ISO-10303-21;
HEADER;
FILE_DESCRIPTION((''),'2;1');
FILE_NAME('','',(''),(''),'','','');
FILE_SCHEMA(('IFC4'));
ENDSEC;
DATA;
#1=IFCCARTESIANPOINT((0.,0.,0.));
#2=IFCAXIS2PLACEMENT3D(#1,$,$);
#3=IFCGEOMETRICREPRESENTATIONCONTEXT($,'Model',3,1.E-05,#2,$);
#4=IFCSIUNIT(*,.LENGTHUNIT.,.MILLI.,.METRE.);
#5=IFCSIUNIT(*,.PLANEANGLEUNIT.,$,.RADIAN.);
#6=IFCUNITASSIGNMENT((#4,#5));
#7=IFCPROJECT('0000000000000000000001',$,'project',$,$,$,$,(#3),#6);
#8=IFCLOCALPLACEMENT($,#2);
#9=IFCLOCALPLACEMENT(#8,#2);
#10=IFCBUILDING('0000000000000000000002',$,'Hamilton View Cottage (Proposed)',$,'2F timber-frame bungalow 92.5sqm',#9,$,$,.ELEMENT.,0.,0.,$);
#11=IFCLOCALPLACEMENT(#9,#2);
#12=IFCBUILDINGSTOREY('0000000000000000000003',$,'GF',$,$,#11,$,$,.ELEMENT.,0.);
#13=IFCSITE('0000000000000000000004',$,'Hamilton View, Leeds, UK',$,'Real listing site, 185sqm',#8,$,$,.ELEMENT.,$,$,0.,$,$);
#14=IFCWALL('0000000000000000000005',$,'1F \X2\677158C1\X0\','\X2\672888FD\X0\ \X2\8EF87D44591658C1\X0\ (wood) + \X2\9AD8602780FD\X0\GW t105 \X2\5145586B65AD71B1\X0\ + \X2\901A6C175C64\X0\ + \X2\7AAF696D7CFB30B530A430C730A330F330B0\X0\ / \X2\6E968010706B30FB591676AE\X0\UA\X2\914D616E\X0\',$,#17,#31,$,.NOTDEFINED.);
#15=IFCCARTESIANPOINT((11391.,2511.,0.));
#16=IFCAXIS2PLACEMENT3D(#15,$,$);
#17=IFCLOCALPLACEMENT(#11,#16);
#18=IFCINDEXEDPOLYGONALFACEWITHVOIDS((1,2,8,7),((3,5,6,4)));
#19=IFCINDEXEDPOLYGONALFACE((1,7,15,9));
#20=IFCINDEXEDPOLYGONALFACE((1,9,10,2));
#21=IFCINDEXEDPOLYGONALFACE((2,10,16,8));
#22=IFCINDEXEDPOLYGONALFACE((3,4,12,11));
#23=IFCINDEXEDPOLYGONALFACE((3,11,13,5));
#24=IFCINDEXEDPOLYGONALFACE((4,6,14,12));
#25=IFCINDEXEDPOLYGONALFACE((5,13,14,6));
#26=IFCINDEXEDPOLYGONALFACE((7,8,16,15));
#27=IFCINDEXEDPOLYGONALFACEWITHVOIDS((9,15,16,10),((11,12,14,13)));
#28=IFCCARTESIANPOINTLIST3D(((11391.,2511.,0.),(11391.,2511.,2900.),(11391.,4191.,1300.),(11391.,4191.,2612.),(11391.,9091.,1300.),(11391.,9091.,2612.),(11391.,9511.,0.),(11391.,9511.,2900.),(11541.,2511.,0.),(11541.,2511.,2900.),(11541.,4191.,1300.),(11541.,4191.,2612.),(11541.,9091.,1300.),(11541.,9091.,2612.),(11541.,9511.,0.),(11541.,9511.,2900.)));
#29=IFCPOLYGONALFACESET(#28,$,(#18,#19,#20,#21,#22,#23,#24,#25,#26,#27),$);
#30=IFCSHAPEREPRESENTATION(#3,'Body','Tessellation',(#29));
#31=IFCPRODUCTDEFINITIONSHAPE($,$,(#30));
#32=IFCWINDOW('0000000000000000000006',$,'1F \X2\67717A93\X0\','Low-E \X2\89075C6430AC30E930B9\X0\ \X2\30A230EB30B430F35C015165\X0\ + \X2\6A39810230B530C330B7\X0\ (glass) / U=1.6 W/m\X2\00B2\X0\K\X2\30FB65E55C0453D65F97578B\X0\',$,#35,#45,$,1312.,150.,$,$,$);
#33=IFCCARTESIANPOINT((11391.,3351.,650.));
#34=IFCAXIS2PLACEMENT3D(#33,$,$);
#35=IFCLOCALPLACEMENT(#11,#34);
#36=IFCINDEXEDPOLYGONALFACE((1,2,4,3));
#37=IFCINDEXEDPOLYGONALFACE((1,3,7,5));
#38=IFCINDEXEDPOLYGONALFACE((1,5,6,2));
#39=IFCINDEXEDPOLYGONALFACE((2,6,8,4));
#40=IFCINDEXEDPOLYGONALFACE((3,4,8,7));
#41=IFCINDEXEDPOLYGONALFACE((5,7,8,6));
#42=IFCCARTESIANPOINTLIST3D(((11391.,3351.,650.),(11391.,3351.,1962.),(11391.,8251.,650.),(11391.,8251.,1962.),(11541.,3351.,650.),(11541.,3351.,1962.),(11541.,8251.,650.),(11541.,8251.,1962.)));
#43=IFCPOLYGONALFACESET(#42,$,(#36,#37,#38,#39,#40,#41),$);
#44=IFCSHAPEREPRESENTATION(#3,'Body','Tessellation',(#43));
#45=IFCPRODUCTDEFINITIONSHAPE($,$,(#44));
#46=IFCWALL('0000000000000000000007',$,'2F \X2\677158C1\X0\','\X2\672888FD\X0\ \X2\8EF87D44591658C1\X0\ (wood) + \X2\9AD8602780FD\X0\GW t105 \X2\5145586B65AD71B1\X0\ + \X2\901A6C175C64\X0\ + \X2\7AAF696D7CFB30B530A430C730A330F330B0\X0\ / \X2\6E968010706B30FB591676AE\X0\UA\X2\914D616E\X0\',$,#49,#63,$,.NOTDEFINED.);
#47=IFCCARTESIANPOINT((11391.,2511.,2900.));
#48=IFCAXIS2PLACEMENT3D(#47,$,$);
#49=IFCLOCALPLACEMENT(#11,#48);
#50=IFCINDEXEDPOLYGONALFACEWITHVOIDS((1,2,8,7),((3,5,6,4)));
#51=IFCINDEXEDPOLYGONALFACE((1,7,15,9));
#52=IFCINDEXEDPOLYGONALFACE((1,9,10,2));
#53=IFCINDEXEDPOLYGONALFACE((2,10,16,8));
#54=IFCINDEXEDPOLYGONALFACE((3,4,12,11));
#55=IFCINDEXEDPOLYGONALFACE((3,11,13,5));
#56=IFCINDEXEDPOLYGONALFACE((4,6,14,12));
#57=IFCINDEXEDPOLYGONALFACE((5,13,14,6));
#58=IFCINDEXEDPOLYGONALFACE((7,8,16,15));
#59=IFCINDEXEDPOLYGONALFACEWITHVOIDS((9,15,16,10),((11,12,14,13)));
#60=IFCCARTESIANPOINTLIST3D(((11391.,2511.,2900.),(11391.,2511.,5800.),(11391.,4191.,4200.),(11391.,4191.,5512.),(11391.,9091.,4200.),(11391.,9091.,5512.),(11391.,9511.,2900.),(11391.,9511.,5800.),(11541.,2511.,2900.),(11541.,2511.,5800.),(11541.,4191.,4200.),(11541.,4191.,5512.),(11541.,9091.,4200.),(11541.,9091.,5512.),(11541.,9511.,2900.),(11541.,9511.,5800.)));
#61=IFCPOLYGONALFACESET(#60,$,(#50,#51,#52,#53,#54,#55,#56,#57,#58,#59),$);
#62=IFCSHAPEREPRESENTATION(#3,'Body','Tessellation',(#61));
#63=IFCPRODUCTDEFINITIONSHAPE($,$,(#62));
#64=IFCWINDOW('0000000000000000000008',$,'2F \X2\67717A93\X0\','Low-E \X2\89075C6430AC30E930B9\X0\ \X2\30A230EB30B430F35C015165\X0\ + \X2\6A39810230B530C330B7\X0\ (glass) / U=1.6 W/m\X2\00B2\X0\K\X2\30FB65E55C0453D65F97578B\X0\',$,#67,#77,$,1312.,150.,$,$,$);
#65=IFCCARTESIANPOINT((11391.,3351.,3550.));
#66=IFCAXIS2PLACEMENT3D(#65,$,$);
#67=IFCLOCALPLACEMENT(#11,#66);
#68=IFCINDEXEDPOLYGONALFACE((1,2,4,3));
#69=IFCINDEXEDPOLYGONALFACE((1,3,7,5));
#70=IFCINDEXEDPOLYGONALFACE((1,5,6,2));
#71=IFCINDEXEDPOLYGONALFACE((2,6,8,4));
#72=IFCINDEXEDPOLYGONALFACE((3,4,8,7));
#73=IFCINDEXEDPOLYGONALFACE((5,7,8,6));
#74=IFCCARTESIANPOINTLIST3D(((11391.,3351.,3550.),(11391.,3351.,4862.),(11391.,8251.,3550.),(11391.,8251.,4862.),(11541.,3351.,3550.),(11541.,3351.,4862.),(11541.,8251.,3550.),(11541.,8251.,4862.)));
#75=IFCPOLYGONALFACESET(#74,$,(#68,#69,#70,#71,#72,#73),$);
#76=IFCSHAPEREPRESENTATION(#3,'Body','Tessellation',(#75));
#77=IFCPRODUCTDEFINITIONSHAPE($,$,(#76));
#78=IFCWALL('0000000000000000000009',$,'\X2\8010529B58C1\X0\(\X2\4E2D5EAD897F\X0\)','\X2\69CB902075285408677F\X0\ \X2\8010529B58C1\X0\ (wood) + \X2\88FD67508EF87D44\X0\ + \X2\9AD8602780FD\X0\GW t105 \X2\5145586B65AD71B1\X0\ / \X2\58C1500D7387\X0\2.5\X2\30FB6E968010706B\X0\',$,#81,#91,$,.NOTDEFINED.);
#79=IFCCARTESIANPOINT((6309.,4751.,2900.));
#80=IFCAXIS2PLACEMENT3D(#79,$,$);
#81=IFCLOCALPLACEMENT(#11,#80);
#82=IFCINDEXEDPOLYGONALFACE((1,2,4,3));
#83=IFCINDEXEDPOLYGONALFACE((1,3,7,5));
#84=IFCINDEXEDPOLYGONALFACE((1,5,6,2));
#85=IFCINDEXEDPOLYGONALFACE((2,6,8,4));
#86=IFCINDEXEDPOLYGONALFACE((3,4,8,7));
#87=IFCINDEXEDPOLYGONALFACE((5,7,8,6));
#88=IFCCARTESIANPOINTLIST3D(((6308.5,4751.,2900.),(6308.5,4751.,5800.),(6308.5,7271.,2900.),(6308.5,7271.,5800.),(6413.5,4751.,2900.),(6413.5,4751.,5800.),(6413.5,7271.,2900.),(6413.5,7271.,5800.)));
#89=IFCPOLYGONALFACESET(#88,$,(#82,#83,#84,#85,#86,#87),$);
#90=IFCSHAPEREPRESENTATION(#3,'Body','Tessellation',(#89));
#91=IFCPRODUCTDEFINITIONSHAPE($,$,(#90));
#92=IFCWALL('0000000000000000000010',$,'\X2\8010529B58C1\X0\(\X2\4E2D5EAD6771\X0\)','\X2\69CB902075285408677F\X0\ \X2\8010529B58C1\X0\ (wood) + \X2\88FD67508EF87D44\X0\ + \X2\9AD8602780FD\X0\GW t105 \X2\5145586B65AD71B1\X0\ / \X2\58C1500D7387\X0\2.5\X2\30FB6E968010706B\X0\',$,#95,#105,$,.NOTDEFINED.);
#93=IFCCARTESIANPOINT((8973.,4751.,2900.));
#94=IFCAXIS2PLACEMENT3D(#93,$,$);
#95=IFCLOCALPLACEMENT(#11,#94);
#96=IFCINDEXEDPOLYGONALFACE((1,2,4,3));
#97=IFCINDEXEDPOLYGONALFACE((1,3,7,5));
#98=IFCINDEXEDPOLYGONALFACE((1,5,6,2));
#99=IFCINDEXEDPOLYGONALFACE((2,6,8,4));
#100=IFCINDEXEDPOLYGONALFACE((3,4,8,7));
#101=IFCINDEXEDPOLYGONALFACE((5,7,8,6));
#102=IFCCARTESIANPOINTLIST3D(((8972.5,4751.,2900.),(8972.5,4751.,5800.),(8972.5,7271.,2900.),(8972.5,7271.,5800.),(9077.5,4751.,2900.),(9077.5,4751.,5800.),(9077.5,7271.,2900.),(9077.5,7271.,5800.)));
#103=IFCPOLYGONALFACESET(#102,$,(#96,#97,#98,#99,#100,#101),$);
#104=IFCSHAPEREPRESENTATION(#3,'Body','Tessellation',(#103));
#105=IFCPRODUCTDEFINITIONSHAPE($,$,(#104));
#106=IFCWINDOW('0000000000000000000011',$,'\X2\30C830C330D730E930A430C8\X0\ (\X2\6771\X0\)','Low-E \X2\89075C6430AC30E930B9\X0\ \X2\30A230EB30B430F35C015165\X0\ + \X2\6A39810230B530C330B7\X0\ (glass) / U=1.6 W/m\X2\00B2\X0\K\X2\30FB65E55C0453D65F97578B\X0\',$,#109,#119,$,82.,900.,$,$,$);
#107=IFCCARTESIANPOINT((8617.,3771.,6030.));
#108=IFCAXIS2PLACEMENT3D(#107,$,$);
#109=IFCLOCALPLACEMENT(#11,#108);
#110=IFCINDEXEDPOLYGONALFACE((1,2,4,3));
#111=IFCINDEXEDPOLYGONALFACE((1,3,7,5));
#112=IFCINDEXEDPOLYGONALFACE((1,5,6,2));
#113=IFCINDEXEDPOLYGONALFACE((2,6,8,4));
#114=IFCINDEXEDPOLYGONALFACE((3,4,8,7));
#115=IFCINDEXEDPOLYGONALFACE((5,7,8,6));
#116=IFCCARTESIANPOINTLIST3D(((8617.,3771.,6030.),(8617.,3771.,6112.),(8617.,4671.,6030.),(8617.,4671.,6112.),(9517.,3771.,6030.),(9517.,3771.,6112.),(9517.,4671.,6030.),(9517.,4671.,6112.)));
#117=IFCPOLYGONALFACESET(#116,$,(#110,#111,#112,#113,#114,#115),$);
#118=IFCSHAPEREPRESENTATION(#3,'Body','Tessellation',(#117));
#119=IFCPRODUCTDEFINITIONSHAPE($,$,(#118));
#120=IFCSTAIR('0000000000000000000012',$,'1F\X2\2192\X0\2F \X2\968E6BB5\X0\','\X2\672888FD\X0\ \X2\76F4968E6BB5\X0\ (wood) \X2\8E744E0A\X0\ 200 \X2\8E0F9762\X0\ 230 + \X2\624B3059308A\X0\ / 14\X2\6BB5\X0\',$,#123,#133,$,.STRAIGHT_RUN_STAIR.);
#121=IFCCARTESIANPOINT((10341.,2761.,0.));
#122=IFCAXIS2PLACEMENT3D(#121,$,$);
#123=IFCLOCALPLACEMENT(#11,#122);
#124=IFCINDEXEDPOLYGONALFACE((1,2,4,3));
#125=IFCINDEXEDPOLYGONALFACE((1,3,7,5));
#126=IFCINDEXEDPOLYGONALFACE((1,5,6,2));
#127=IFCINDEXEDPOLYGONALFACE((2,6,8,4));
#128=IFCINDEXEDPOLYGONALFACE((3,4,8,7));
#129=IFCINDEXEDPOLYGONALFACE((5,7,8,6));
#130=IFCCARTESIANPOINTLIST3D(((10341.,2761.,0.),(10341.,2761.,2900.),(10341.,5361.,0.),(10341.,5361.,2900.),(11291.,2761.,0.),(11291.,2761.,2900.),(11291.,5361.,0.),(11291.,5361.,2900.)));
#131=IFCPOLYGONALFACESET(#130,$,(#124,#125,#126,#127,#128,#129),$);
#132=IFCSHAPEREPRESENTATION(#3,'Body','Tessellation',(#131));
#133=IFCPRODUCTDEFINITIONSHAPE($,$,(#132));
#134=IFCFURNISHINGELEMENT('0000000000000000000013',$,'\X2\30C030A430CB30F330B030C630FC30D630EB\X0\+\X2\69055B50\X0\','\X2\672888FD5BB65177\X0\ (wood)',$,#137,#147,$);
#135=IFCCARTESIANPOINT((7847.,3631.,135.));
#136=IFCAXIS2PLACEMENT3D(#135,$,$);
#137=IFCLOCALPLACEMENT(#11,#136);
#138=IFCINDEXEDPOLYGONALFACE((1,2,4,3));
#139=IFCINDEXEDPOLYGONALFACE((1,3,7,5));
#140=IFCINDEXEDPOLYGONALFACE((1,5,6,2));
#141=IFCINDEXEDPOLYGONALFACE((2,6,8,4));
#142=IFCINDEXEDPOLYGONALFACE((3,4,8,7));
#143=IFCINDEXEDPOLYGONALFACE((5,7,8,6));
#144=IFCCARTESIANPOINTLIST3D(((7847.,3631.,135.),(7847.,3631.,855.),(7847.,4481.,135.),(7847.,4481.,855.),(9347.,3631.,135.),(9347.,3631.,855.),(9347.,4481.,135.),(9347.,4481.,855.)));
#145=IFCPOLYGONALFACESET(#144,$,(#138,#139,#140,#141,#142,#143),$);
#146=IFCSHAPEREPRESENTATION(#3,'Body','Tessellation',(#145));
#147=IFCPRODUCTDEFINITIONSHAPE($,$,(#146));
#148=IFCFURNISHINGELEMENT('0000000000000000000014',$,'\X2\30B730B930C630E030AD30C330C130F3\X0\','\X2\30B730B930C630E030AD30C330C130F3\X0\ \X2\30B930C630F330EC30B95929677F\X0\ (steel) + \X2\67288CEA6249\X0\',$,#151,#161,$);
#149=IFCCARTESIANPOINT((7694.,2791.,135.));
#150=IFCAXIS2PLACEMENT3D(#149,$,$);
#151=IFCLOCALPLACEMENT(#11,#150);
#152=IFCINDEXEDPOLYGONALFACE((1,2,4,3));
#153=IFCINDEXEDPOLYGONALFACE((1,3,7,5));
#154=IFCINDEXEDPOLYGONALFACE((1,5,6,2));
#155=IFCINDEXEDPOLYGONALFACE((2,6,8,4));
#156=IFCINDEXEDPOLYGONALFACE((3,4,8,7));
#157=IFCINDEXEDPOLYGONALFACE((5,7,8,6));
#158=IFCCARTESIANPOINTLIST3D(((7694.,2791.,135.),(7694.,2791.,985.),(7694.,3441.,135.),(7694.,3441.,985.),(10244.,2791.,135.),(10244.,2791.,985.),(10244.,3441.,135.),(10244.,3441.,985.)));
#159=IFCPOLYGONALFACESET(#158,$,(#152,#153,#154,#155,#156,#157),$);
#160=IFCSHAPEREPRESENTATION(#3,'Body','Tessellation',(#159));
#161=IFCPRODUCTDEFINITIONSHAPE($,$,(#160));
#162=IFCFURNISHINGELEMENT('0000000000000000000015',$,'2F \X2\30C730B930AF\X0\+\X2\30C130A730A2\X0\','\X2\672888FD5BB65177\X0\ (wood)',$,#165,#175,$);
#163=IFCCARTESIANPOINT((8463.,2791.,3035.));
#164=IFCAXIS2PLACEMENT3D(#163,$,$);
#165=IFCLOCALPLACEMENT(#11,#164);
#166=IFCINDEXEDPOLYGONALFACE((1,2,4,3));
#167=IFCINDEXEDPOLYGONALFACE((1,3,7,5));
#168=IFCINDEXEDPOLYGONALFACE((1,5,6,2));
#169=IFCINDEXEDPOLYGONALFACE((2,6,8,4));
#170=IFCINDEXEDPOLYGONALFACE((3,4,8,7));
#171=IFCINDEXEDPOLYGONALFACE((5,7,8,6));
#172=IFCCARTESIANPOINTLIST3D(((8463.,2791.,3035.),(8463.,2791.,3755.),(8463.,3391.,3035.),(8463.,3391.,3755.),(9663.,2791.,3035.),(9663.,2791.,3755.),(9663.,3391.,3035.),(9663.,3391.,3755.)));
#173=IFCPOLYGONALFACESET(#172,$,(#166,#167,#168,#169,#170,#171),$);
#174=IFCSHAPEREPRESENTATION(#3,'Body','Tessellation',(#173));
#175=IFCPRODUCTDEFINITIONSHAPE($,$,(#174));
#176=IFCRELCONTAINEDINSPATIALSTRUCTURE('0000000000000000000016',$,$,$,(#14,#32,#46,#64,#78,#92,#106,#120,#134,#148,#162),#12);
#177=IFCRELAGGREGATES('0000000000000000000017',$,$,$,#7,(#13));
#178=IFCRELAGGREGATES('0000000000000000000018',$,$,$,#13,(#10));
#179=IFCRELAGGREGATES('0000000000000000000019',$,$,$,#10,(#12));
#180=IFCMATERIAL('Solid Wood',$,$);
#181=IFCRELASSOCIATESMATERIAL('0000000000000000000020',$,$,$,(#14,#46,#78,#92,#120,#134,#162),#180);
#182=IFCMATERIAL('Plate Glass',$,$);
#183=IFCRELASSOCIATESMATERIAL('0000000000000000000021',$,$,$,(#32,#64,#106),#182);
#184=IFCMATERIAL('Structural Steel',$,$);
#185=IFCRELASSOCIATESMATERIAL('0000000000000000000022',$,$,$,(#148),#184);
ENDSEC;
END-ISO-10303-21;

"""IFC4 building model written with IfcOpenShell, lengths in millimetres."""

from ifc_helpers import new_model, si_unit, frame, frame_2d, origin, place, context, project, spatial, rectangle, extrude, material, element, fill, save


model = new_model("IFC4")

# Units and contexts
model_context = context("Model", 3, precision=1e-05, world=origin())
ifc_project = project(units=[si_unit("LENGTHUNIT", "METRE", prefix="MILLI"), si_unit("PLANEANGLEUNIT", "RADIAN")], contexts=[model_context])

# Site, building, storey
site_placement = place(None, origin())
site = spatial("IfcSite", under=ifc_project, at=site_placement, Name="Hamilton View, Leeds, UK", ObjectType="Real listing site, 185sqm", CompositionType="ELEMENT", RefElevation=0.0)
building_placement = place(site_placement, origin())
building = spatial("IfcBuilding", under=site, at=building_placement, Name="Hamilton View Cottage (Proposed)", ObjectType="2F timber-frame bungalow 92.5sqm", CompositionType="ELEMENT", ElevationOfRefHeight=0.0, ElevationOfTerrain=0.0)
storey_placement = place(building_placement, origin())
storey = spatial("IfcBuildingStorey", under=building, at=storey_placement, Name="GF", CompositionType="ELEMENT", Elevation=0.0)

# Shared definitions
ifc_material_1 = material(Name="Solid Wood")

# Wall, opening, window
wall_1_placement = place(storey_placement, frame((11391.0, 2511.0, 0.0)))
wall_1 = element("IfcWall", 1, at=wall_1_placement, inside=storey, material=ifc_material_1, Name="1F 東壁", Description="木製 軸組外壁 (wood) + 高性能GW t105 充填断熱 + 通気層 + 窯業系サイディング / 準耐火・外皮UA配慮", PredefinedType="NOTDEFINED", context=model_context, shape_type="SweptSolid", body=[
    extrude(rectangle(XDim=150.0, YDim=7000.0, at=frame_2d((75.0, 3500.0))), frame((11391.0, 2511.0, 0.0)), (0.0, 0.0, 1.0), 2900.0),
])
opening_1_placement = place(storey_placement, frame((11391.0, 3351.0, 650.0)))
opening_1 = element("IfcOpeningElement", 2, at=opening_1_placement, cuts=wall_1, PredefinedType="NOTDEFINED", context=model_context, shape_type="SweptSolid", body=[
    extrude(rectangle(XDim=150.0, YDim=4900.0, at=frame_2d((75.0, 2450.0))), frame((11391.0, 3351.0, 650.0)), (0.0, 0.0, 1.0), 1312.0),
])
ifc_material_2 = material(Name="Plate Glass")
window_1_placement = place(storey_placement, frame((11391.0, 3351.0, 650.0)))
window_1 = element("IfcWindow", 3, at=window_1_placement, inside=storey, material=ifc_material_2, Name="1F 東窓", Description="Low-E 複層ガラス アルゴン封入 + 樹脂サッシ (glass) / U=1.6 W/m²K・日射取得型", OverallHeight=1312.0, OverallWidth=150.0, context=model_context, shape_type="SweptSolid", body=[
    extrude(rectangle(XDim=150.0, YDim=4900.0, at=frame_2d((75.0, 2450.0))), frame((11391.0, 3351.0, 650.0)), (0.0, 0.0, 1.0), 1312.0),
])
fill(opening_1, window_1)

# Wall, opening, window
wall_2_placement = place(storey_placement, frame((11391.0, 2511.0, 2900.0)))
wall_2 = element("IfcWall", 4, at=wall_2_placement, inside=storey, material=ifc_material_1, Name="2F 東壁", Description="木製 軸組外壁 (wood) + 高性能GW t105 充填断熱 + 通気層 + 窯業系サイディング / 準耐火・外皮UA配慮", PredefinedType="NOTDEFINED", context=model_context, shape_type="SweptSolid", body=[
    extrude(rectangle(XDim=150.0, YDim=7000.0, at=frame_2d((75.0, 3500.0))), frame((11391.0, 2511.0, 2900.0)), (0.0, 0.0, 1.0), 2900.0),
])
opening_2_placement = place(storey_placement, frame((11391.0, 3351.0, 3550.0)))
opening_2 = element("IfcOpeningElement", 5, at=opening_2_placement, cuts=wall_2, PredefinedType="NOTDEFINED", context=model_context, shape_type="SweptSolid", body=[
    extrude(rectangle(XDim=150.0, YDim=4900.0, at=frame_2d((75.0, 2450.0))), frame((11391.0, 3351.0, 3550.0)), (0.0, 0.0, 1.0), 1312.0),
])
window_2_placement = place(storey_placement, frame((11391.0, 3351.0, 3550.0)))
window_2 = element("IfcWindow", 6, at=window_2_placement, inside=storey, material=ifc_material_2, Name="2F 東窓", Description="Low-E 複層ガラス アルゴン封入 + 樹脂サッシ (glass) / U=1.6 W/m²K・日射取得型", OverallHeight=1312.0, OverallWidth=150.0, context=model_context, shape_type="SweptSolid", body=[
    extrude(rectangle(XDim=150.0, YDim=4900.0, at=frame_2d((75.0, 2450.0))), frame((11391.0, 3351.0, 3550.0)), (0.0, 0.0, 1.0), 1312.0),
])
fill(opening_2, window_2)

# Walls
wall_3_placement = place(storey_placement, frame((6309.0, 4751.0, 2900.0)))
element("IfcWall", 7, at=wall_3_placement, inside=storey, material=ifc_material_1, Name="耐力壁(中庭西)", Description="構造用合板 耐力壁 (wood) + 製材軸組 + 高性能GW t105 充填断熱 / 壁倍率2.5・準耐火", PredefinedType="NOTDEFINED", context=model_context, shape_type="SweptSolid", body=[
    extrude(rectangle(XDim=105.0, YDim=2520.0, at=frame_2d((52.0, 1260.0))), frame((6309.0, 4751.0, 2900.0)), (0.0, 0.0, 1.0), 2900.0),
])
wall_4_placement = place(storey_placement, frame((8973.0, 4751.0, 2900.0)))
element("IfcWall", 8, at=wall_4_placement, inside=storey, material=ifc_material_1, Name="耐力壁(中庭東)", Description="構造用合板 耐力壁 (wood) + 製材軸組 + 高性能GW t105 充填断熱 / 壁倍率2.5・準耐火", PredefinedType="NOTDEFINED", context=model_context, shape_type="SweptSolid", body=[
    extrude(rectangle(XDim=105.0, YDim=2520.0, at=frame_2d((52.0, 1260.0))), frame((8973.0, 4751.0, 2900.0)), (0.0, 0.0, 1.0), 2900.0),
])

# Window
window_3_placement = place(storey_placement, frame((8617.0, 3771.0, 6030.0)))
element("IfcWindow", 9, at=window_3_placement, inside=storey, material=ifc_material_2, Name="トップライト (東)", Description="Low-E 複層ガラス アルゴン封入 + 樹脂サッシ (glass) / U=1.6 W/m²K・日射取得型", OverallHeight=82.0, OverallWidth=900.0, context=model_context, shape_type="SweptSolid", body=[
    extrude(rectangle(XDim=900.0, YDim=900.0, at=frame_2d((450.0, 450.0))), frame((8617.0, 3771.0, 6030.0)), (0.0, 0.0, 1.0), 82.0),
])

# Stair
stair_placement = place(storey_placement, frame((10341.0, 2761.0, 0.0)))
element("IfcStair", 10, at=stair_placement, inside=storey, material=ifc_material_1, Name="1F→2F 階段", Description="木製 直階段 (wood) 蹴上 200 踏面 230 + 手すり / 14段", PredefinedType="STRAIGHT_RUN_STAIR", context=model_context, shape_type="SweptSolid", body=[
    extrude(rectangle(XDim=950.0, YDim=2600.0, at=frame_2d((475.0, 1300.0))), frame((10341.0, 2761.0, 0.0)), (0.0, 0.0, 1.0), 2900.0),
])

# Furnishing elements
furnishing_1_placement = place(storey_placement, frame((7847.0, 3631.0, 135.0)))
element("IfcFurnishingElement", 11, at=furnishing_1_placement, inside=storey, material=ifc_material_1, Name="ダイニングテーブル+椅子", Description="木製家具 (wood)", context=model_context, shape_type="SweptSolid", body=[
    extrude(rectangle(XDim=1500.0, YDim=850.0, at=frame_2d((750.0, 425.0))), frame((7847.0, 3631.0, 135.0)), (0.0, 0.0, 1.0), 720.0),
])
ifc_material_3 = material(Name="Structural Steel")
furnishing_2_placement = place(storey_placement, frame((7694.0, 2791.0, 135.0)))
element("IfcFurnishingElement", 12, at=furnishing_2_placement, inside=storey, material=ifc_material_3, Name="システムキッチン", Description="システムキッチン ステンレス天板 (steel) + 木質扉", context=model_context, shape_type="SweptSolid", body=[
    extrude(rectangle(XDim=2550.0, YDim=650.0, at=frame_2d((1275.0, 325.0))), frame((7694.0, 2791.0, 135.0)), (0.0, 0.0, 1.0), 850.0),
])
furnishing_3_placement = place(storey_placement, frame((8463.0, 2791.0, 3035.0)))
element("IfcFurnishingElement", 13, at=furnishing_3_placement, inside=storey, material=ifc_material_1, Name="2F デスク+チェア", Description="木製家具 (wood)", context=model_context, shape_type="SweptSolid", body=[
    extrude(rectangle(XDim=1200.0, YDim=600.0, at=frame_2d((600.0, 300.0))), frame((8463.0, 2791.0, 3035.0)), (0.0, 0.0, 1.0), 720.0),
])

save(model, "model.ifc")
